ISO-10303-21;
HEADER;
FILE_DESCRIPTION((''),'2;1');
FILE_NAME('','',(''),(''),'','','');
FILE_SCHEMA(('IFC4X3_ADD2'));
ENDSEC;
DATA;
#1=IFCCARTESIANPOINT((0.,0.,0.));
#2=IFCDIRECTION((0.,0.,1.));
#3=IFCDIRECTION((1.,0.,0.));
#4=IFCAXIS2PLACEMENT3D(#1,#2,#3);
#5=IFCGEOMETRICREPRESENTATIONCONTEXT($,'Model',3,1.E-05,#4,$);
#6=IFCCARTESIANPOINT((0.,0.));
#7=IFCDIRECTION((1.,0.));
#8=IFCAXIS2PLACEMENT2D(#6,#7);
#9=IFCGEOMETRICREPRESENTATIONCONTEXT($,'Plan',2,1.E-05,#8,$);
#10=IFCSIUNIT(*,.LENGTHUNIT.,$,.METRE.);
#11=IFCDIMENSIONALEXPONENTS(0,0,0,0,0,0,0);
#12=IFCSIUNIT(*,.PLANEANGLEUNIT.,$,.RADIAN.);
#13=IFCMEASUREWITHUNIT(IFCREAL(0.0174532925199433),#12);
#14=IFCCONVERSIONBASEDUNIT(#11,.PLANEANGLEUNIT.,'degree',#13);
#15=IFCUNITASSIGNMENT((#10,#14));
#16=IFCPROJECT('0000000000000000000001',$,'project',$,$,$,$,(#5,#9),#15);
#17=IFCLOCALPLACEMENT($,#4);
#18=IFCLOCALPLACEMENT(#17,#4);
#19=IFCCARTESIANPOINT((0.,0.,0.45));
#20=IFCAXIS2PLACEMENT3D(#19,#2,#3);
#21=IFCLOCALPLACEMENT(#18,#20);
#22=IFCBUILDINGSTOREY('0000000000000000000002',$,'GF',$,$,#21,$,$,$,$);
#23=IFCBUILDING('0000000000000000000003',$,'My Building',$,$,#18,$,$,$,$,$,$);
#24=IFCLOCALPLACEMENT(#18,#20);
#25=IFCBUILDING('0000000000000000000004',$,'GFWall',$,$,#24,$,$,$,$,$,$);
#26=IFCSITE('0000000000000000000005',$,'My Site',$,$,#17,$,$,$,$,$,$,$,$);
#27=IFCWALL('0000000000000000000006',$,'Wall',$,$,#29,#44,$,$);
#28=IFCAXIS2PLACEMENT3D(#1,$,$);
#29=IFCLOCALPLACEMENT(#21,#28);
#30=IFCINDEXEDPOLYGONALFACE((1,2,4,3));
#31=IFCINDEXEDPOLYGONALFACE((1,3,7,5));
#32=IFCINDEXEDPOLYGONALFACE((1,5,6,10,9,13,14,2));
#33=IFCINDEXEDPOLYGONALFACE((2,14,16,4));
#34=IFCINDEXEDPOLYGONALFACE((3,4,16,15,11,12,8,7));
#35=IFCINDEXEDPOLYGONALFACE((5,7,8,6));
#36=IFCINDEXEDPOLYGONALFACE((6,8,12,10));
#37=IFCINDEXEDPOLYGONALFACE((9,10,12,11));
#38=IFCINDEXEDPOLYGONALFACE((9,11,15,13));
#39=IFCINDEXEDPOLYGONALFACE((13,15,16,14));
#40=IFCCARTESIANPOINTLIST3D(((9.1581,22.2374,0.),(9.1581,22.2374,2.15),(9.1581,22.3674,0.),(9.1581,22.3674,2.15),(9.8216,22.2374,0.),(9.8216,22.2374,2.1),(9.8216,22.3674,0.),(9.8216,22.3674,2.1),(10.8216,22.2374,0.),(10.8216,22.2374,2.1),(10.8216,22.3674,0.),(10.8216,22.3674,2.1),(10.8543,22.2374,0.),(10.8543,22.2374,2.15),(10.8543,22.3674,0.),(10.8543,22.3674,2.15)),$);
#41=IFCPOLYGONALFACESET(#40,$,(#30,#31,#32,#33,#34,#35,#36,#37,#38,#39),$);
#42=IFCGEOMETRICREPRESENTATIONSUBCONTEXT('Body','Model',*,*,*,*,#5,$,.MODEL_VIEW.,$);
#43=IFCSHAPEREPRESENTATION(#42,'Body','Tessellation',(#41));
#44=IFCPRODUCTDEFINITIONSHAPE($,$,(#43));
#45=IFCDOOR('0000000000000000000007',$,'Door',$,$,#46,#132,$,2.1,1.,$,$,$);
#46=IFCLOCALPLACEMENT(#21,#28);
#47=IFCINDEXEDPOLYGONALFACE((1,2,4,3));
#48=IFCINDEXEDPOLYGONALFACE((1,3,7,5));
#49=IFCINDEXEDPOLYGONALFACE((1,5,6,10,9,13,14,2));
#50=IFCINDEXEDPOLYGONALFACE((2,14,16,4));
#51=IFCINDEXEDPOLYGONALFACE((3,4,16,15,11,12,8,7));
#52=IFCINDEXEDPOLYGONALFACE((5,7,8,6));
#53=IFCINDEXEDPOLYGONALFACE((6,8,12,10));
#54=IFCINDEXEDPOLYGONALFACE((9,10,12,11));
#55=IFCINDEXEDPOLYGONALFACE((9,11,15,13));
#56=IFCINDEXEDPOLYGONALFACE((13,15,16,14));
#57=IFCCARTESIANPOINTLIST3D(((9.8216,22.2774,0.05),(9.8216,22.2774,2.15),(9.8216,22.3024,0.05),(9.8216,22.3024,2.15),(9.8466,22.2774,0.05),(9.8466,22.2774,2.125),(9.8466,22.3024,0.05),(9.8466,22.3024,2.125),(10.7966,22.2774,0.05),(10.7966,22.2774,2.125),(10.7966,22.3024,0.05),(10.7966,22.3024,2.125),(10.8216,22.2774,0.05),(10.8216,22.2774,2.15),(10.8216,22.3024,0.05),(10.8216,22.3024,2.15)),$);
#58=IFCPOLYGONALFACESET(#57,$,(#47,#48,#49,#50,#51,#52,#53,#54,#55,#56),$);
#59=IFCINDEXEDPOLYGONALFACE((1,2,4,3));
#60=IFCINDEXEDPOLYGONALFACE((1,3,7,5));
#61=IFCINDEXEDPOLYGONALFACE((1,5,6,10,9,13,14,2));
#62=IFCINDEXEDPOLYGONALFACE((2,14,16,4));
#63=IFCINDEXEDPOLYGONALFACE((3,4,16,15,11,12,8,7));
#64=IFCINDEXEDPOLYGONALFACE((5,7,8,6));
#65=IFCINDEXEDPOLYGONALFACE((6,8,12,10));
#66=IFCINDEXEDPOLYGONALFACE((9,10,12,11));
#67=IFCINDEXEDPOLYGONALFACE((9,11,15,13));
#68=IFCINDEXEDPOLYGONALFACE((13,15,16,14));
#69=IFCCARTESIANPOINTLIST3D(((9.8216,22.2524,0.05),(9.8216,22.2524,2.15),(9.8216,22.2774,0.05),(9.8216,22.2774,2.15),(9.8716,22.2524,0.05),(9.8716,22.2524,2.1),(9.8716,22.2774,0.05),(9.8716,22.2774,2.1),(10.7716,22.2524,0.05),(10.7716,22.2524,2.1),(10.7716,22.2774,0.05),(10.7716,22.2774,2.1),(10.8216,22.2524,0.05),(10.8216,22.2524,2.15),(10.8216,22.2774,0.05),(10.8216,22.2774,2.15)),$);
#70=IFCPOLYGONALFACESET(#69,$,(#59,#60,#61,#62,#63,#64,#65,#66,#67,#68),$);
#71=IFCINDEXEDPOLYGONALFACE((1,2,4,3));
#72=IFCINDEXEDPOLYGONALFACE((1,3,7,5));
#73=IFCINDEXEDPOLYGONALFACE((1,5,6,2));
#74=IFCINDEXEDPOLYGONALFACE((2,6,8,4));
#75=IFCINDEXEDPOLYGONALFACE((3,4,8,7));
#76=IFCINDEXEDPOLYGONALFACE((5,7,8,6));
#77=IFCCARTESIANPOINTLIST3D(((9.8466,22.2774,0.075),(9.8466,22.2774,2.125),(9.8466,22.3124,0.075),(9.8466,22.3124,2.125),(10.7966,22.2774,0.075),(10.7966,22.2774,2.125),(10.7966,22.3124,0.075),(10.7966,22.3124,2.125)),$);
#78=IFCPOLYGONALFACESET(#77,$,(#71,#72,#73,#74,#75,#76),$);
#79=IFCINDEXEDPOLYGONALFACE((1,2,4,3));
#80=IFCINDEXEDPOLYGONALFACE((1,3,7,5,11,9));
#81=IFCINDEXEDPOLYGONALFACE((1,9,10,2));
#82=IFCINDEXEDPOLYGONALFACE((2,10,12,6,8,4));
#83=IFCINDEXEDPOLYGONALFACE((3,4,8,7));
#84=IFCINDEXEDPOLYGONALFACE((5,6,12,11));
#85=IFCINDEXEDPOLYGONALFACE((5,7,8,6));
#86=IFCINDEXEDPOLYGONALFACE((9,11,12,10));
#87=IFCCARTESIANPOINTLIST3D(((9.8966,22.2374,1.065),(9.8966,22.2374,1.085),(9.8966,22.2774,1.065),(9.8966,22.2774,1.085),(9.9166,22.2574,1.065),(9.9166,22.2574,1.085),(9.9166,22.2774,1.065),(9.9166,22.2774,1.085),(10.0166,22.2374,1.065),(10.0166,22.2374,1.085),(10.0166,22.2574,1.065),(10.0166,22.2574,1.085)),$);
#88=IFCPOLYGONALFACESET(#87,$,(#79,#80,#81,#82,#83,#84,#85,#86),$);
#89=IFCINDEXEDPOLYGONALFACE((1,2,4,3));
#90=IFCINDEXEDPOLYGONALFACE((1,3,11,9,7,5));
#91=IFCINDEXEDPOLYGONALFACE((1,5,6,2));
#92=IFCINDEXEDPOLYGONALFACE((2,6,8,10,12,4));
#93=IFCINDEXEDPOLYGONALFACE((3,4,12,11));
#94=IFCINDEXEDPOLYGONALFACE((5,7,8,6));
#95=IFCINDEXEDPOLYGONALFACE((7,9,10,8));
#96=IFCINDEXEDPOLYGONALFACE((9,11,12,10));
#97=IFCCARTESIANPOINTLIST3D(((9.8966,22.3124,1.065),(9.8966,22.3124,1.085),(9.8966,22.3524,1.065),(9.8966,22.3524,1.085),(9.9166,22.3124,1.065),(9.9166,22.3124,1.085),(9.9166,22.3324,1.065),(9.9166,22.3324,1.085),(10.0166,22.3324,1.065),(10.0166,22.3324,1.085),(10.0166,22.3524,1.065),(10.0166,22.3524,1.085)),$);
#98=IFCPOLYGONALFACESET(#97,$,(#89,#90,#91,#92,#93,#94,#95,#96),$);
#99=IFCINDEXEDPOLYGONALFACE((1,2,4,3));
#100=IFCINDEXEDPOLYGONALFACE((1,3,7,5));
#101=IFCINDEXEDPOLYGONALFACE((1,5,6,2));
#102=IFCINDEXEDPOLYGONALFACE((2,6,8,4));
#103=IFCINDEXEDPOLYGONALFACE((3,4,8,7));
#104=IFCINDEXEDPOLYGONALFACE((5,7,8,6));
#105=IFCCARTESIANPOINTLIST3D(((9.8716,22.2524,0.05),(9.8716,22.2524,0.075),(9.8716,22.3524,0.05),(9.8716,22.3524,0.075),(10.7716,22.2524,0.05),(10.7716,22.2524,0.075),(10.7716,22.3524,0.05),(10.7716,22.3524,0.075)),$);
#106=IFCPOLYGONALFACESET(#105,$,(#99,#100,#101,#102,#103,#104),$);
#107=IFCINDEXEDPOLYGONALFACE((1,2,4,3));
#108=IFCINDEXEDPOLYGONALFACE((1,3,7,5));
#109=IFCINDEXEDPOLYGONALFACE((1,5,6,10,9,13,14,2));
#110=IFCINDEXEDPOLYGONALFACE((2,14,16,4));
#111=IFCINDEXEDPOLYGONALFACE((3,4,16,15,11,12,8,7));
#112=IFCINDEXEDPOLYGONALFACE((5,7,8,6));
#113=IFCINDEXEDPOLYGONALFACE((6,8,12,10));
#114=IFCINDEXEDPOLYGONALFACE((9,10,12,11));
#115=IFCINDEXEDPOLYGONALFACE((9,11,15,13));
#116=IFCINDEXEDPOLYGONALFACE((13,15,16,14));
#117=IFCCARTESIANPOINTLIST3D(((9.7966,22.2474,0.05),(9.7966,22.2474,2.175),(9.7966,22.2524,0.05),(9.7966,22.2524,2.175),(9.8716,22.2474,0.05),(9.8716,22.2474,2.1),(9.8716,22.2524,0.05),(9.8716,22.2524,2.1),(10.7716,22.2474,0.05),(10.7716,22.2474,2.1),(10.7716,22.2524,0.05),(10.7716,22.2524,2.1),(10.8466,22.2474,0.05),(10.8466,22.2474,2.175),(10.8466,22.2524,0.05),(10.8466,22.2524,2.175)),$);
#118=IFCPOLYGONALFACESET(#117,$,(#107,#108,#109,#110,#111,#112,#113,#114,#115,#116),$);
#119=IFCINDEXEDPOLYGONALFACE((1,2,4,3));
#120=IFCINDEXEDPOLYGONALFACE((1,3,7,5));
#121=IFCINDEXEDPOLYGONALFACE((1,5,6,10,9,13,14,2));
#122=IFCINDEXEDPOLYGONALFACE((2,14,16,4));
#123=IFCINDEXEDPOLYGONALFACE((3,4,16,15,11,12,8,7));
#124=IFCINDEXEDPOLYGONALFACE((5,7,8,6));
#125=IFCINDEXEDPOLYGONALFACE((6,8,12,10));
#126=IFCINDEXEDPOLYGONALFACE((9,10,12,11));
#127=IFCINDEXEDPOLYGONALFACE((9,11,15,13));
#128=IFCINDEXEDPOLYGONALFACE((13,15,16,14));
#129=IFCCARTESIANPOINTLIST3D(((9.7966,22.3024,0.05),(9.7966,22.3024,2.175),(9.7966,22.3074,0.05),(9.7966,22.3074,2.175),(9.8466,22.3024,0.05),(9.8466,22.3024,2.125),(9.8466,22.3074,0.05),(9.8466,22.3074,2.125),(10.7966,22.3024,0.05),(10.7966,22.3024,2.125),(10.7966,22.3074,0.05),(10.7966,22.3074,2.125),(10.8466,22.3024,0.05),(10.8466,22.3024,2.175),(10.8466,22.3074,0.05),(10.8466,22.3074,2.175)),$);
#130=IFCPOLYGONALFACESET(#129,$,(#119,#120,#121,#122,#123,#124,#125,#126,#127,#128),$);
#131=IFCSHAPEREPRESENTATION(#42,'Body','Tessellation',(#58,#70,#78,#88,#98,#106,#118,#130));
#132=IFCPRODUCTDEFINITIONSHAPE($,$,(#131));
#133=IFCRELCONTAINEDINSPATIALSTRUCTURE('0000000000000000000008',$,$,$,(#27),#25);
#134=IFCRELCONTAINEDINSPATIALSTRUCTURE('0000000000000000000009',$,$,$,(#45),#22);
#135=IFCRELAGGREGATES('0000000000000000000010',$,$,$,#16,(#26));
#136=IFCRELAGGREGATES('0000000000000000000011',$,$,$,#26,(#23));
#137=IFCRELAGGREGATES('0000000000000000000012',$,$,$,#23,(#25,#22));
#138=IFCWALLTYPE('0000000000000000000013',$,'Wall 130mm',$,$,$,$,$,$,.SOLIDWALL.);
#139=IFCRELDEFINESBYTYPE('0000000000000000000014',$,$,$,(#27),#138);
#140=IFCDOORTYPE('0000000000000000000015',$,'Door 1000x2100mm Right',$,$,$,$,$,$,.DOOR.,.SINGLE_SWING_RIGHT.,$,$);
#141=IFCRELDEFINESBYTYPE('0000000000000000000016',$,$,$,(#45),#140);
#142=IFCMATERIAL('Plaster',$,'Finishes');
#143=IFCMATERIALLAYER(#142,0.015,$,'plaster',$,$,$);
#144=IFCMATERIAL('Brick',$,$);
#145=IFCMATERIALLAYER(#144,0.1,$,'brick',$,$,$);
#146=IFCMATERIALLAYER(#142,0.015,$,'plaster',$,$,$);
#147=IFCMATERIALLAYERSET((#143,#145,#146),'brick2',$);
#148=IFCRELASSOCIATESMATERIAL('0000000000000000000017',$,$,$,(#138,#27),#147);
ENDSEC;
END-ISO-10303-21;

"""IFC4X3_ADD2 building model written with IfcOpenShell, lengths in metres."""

from ifc_helpers import new_model, entity, si_unit, converted_unit, frame, origin_with_axes, origin_2d_with_axis, place, context, subcontext, project, spatial, line, indexed_curve, outline, extrude, shape, source, transform, mapped, material, layer, layer_set, layer_usage, type_object, type_shapes, element, fill, save


model = new_model("IFC4X3_ADD2")

# Units and contexts
model_context = context("Model", 3, precision=1e-05, world=origin_with_axes())
plan_context = context("Plan", 2, precision=1e-05, world=origin_2d_with_axis())
body_context_1 = subcontext(model_context, "Body", "Model", "MODEL_VIEW")
body_context_2 = subcontext(plan_context, "Body", "Plan", "PLAN_VIEW")
ifc_project = project(units=[si_unit("LENGTHUNIT", "METRE"), converted_unit("PLANEANGLEUNIT", "degree", entity("IfcReal", 0.0174532925199433), si_unit("PLANEANGLEUNIT", "RADIAN"), dimensions=[0, 0, 0, 0, 0, 0, 0])], contexts=[model_context, plan_context])

# Site, buildings
site_placement = place(None, origin_with_axes())
site = spatial("IfcSite", under=ifc_project, at=site_placement, Name="My Site")
building_1_placement = place(site_placement, origin_with_axes())
building_1 = spatial("IfcBuilding", under=site, at=building_1_placement, Name="My Building")
building_2_placement = place(building_1_placement, frame((0.0, 0.0, 0.45), z_axis=(0.0, 0.0, 1.0), x_axis=(1.0, 0.0, 0.0)))
building_2 = spatial("IfcBuilding", under=building_1, at=building_2_placement, Name="GFWall")

# Wall, opening
ifc_material_1 = material(Name="Plaster", Category="Finishes")
ifc_layer_1 = layer(ifc_material_1, 0.015, Name="plaster")
ifc_material_2 = material(Name="Brick")
ifc_layer_2 = layer(ifc_material_2, 0.1, Name="brick")
ifc_layer_3 = layer(ifc_material_1, 0.015, Name="plaster")
ifc_layer_set_1 = layer_set([ifc_layer_1, ifc_layer_2, ifc_layer_3], Name="brick2")
ifc_layer_usage_1 = layer_usage(ifc_layer_set_1, "AXIS2", "POSITIVE", 0.0)
wall_type_1 = type_object("IfcWallType", Name="Wall 130mm", PredefinedType="SOLIDWALL", material=ifc_layer_set_1)
wall_1_placement = place(building_2_placement, frame((9.1581, 22.2374, 0.0), z_axis=(0.0, 0.0, 1.0), x_axis=(1.0, 0.0, 0.0)))
wall_1 = element("IfcWall", 1, at=wall_1_placement, inside=building_2, type_object=wall_type_1, material=ifc_layer_usage_1, Name="Wall", context=body_context_1, shape_type="SweptSolid", body=[
    extrude(outline(indexed_curve([(0.0, 0.0), (0.0, 0.13), (1.6962, 0.13), (1.6962, 0.0)], segments=[line(1, 2, 3, 4, 1)])), origin_with_axes(), (0.0, 0.0, 1.0), 2.15),
])
shared_shape_1 = source(origin_with_axes(), body_context_1, "Body", "SweptSolid", [
    extrude(outline(indexed_curve([(0.0, 0.0), (1.0, 0.0), (1.0, 2.1), (0.0, 2.1)], segments=[line(1, 2, 3, 4, 1)])), frame((0.0, -0.6, 0.0), z_axis=(0.0, -1.0, 0.0), x_axis=(1.0, 0.0, 0.0)), (0.0, 0.0, -1.0), 1.2),
])
opening_1_placement = place(wall_1_placement, frame((0.6635, 0.0, 0.0), z_axis=(0.0, 0.0, 1.0), x_axis=(1.0, 0.0, 0.0)))
opening_1 = element("IfcOpeningElement", 2, at=opening_1_placement, cuts=wall_1, PredefinedType="OPENING", context=body_context_1, shape_type="MappedRepresentation", body=[
    mapped(shared_shape_1, transform((0.0, 0.0, 0.0), x_axis=(1.0, 0.0, 0.0), y_axis=(0.0, 1.0, 0.0), z_axis=(0.0, 0.0, 1.0), scale=1.0)),
])

# Shared definitions
storey_placement = place(building_1_placement, frame((0.0, 0.0, 0.45), z_axis=(0.0, 0.0, 1.0), x_axis=(1.0, 0.0, 0.0)))
storey = spatial("IfcBuildingStorey", under=building_1, at=storey_placement, Name="GF")

# Door
door_type_1 = type_object("IfcDoorType", Name="Door 1000x2100mm Right", OperationType="SINGLE_SWING_RIGHT", PredefinedType="DOOR")
shared_shape_2 = source(origin_with_axes(), body_context_1, "Body", "SweptSolid", [
    extrude(outline(indexed_curve([(0.0, 0.0), (0.0, 2.1), (1.0, 2.1), (1.0, 0.0), (0.975, 0.0), (0.975, 2.075), (0.025, 2.075), (0.025, 0.0)], segments=[line(1, 2, 3, 4, 5, 6, 7, 8, 1)])), frame((0.0, 0.025, 0.0), z_axis=(0.0, -1.0, 0.0), x_axis=(1.0, 0.0, 0.0)), (0.0, 0.0, -1.0), 0.025),
    extrude(outline(indexed_curve([(0.0, 0.0), (0.0, 2.1), (1.0, 2.1), (1.0, 0.0), (0.95, 0.0), (0.95, 2.05), (0.05, 2.05), (0.05, 0.0)], segments=[line(1, 2, 3, 4, 5, 6, 7, 8, 1)])), frame((0.0, 0.0, 0.0), z_axis=(0.0, -1.0, 0.0), x_axis=(1.0, 0.0, 0.0)), (0.0, 0.0, -1.0), 0.025),
    extrude(outline(indexed_curve([(0.0, 0.0), (0.95, 0.0), (0.95, 0.035), (0.0, 0.035)], segments=[line(1, 2, 3, 4, 1)])), frame((0.025, 0.025, 0.025), z_axis=(0.0, 0.0, 1.0), x_axis=(1.0, 0.0, 0.0)), (0.0, 0.0, 1.0), 2.05),
    extrude(outline(indexed_curve([(0.0, 0.0), (0.0, -0.04), (0.12, -0.04), (0.12, -0.02), (0.02, -0.02), (0.02, 0.0)], segments=[line(1, 2, 3, 4, 5, 6, 1)])), frame((0.075, 0.025, 1.015), z_axis=(0.0, 0.0, 1.0), x_axis=(1.0, 0.0, 0.0)), (0.0, 0.0, 1.0), 0.02),
    extrude(outline(indexed_curve([(0.0, 0.0), (0.0, 0.04), (0.12, 0.04), (0.12, 0.02), (0.02, 0.02), (0.02, 0.0)], segments=[line(1, 2, 3, 4, 5, 6, 1)])), frame((0.075, 0.06, 1.015), z_axis=(0.0, 0.0, 1.0), x_axis=(1.0, 0.0, 0.0)), (0.0, 0.0, 1.0), 0.02),
    extrude(outline(indexed_curve([(0.0, 0.0), (0.9, 0.0), (0.9, 0.1), (0.0, 0.1)], segments=[line(1, 2, 3, 4, 1)])), frame((0.05, 0.0, 0.0), z_axis=(0.0, 0.0, 1.0), x_axis=(1.0, 0.0, 0.0)), (0.0, 0.0, 1.0), 0.025),
    extrude(outline(indexed_curve([(0.0, 0.0), (0.0, 2.125), (1.05, 2.125), (1.05, 0.0), (0.975, 0.0), (0.975, 2.05), (0.075, 2.05), (0.075, 0.0)], segments=[line(1, 2, 3, 4, 5, 6, 7, 8, 1)])), frame((-0.025, -0.005, 0.0), z_axis=(0.0, -1.0, 0.0), x_axis=(1.0, 0.0, 0.0)), (0.0, 0.0, -1.0), 0.005),
    extrude(outline(indexed_curve([(0.0, 0.0), (0.0, 2.125), (1.05, 2.125), (1.05, 0.0), (1.0, 0.0), (1.0, 2.075), (0.05, 2.075), (0.05, 0.0)], segments=[line(1, 2, 3, 4, 5, 6, 7, 8, 1)])), frame((-0.025, 0.05, 0.0), z_axis=(0.0, -1.0, 0.0), x_axis=(1.0, 0.0, 0.0)), (0.0, 0.0, -1.0), 0.005),
])
shared_shape_3 = source(origin_with_axes(), body_context_2, "Body", "Curve2D", [
    entity("IfcIndexedPolyCurve", entity("IfcCartesianPointList2D", [[0.0, 0.0], [0.0, 0.05], [0.025, 0.05], [0.025, 0.025], [0.05, 0.025], [0.05, 0.0]]), [entity("IfcLineIndex", [1, 2, 3, 4, 5, 6, 1])]),
    entity("IfcIndexedPolyCurve", entity("IfcCartesianPointList2D", [[1.0, 0.0], [1.0, 0.05], [0.975, 0.05], [0.975, 0.025], [0.95, 0.025], [0.95, 0.0]]), [entity("IfcLineIndex", [1, 2, 3, 4, 5, 6, 1])]),
    entity("IfcTrimmedCurve", entity("IfcEllipse", entity("IfcAxis2Placement2D", entity("IfcCartesianPoint", [0.94, 0.05]), entity("IfcDirection", [1.0, 0.0])), 0.915, 0.95), [entity("IfcCartesianPoint", [0.94, 1.0])], [entity("IfcCartesianPoint", [0.025, 0.05])], True, "CARTESIAN"),
    entity("IfcIndexedPolyCurve", entity("IfcCartesianPointList2D", [[0.975, 0.05], [0.94, 0.05], [0.94, 1.0], [0.975, 1.0]]), [entity("IfcLineIndex", [1, 2, 3, 4, 1])]),
])
type_shapes(door_type_1, [shared_shape_2, shared_shape_3])
door_1_placement = place(opening_1_placement, frame((0.0, 0.015, 0.05), z_axis=(0.0, 0.0, 1.0), x_axis=(1.0, 0.0, 0.0)))
door_1 = element("IfcDoor", 3, at=door_1_placement, inside=storey, type_object=door_type_1, Name="Door", OverallHeight=2.1, OverallWidth=1.0, shapes=[
    shape(body_context_1, "Body", "MappedRepresentation", [mapped(shared_shape_2, transform((0.0, 0.0, 0.0), x_axis=(1.0, 0.0, 0.0), y_axis=(0.0, 1.0, 0.0), z_axis=(0.0, 0.0, 1.0), scale=1.0))]),
    shape(body_context_2, "Body", "MappedRepresentation", [mapped(shared_shape_3, transform((0.0, 0.0, 0.0), x_axis=(1.0, 0.0, 0.0), y_axis=(0.0, 1.0, 0.0), z_axis=(0.0, 0.0, 1.0), scale=1.0))]),
])
fill(opening_1, door_1)

save(model, "model.ifc")
